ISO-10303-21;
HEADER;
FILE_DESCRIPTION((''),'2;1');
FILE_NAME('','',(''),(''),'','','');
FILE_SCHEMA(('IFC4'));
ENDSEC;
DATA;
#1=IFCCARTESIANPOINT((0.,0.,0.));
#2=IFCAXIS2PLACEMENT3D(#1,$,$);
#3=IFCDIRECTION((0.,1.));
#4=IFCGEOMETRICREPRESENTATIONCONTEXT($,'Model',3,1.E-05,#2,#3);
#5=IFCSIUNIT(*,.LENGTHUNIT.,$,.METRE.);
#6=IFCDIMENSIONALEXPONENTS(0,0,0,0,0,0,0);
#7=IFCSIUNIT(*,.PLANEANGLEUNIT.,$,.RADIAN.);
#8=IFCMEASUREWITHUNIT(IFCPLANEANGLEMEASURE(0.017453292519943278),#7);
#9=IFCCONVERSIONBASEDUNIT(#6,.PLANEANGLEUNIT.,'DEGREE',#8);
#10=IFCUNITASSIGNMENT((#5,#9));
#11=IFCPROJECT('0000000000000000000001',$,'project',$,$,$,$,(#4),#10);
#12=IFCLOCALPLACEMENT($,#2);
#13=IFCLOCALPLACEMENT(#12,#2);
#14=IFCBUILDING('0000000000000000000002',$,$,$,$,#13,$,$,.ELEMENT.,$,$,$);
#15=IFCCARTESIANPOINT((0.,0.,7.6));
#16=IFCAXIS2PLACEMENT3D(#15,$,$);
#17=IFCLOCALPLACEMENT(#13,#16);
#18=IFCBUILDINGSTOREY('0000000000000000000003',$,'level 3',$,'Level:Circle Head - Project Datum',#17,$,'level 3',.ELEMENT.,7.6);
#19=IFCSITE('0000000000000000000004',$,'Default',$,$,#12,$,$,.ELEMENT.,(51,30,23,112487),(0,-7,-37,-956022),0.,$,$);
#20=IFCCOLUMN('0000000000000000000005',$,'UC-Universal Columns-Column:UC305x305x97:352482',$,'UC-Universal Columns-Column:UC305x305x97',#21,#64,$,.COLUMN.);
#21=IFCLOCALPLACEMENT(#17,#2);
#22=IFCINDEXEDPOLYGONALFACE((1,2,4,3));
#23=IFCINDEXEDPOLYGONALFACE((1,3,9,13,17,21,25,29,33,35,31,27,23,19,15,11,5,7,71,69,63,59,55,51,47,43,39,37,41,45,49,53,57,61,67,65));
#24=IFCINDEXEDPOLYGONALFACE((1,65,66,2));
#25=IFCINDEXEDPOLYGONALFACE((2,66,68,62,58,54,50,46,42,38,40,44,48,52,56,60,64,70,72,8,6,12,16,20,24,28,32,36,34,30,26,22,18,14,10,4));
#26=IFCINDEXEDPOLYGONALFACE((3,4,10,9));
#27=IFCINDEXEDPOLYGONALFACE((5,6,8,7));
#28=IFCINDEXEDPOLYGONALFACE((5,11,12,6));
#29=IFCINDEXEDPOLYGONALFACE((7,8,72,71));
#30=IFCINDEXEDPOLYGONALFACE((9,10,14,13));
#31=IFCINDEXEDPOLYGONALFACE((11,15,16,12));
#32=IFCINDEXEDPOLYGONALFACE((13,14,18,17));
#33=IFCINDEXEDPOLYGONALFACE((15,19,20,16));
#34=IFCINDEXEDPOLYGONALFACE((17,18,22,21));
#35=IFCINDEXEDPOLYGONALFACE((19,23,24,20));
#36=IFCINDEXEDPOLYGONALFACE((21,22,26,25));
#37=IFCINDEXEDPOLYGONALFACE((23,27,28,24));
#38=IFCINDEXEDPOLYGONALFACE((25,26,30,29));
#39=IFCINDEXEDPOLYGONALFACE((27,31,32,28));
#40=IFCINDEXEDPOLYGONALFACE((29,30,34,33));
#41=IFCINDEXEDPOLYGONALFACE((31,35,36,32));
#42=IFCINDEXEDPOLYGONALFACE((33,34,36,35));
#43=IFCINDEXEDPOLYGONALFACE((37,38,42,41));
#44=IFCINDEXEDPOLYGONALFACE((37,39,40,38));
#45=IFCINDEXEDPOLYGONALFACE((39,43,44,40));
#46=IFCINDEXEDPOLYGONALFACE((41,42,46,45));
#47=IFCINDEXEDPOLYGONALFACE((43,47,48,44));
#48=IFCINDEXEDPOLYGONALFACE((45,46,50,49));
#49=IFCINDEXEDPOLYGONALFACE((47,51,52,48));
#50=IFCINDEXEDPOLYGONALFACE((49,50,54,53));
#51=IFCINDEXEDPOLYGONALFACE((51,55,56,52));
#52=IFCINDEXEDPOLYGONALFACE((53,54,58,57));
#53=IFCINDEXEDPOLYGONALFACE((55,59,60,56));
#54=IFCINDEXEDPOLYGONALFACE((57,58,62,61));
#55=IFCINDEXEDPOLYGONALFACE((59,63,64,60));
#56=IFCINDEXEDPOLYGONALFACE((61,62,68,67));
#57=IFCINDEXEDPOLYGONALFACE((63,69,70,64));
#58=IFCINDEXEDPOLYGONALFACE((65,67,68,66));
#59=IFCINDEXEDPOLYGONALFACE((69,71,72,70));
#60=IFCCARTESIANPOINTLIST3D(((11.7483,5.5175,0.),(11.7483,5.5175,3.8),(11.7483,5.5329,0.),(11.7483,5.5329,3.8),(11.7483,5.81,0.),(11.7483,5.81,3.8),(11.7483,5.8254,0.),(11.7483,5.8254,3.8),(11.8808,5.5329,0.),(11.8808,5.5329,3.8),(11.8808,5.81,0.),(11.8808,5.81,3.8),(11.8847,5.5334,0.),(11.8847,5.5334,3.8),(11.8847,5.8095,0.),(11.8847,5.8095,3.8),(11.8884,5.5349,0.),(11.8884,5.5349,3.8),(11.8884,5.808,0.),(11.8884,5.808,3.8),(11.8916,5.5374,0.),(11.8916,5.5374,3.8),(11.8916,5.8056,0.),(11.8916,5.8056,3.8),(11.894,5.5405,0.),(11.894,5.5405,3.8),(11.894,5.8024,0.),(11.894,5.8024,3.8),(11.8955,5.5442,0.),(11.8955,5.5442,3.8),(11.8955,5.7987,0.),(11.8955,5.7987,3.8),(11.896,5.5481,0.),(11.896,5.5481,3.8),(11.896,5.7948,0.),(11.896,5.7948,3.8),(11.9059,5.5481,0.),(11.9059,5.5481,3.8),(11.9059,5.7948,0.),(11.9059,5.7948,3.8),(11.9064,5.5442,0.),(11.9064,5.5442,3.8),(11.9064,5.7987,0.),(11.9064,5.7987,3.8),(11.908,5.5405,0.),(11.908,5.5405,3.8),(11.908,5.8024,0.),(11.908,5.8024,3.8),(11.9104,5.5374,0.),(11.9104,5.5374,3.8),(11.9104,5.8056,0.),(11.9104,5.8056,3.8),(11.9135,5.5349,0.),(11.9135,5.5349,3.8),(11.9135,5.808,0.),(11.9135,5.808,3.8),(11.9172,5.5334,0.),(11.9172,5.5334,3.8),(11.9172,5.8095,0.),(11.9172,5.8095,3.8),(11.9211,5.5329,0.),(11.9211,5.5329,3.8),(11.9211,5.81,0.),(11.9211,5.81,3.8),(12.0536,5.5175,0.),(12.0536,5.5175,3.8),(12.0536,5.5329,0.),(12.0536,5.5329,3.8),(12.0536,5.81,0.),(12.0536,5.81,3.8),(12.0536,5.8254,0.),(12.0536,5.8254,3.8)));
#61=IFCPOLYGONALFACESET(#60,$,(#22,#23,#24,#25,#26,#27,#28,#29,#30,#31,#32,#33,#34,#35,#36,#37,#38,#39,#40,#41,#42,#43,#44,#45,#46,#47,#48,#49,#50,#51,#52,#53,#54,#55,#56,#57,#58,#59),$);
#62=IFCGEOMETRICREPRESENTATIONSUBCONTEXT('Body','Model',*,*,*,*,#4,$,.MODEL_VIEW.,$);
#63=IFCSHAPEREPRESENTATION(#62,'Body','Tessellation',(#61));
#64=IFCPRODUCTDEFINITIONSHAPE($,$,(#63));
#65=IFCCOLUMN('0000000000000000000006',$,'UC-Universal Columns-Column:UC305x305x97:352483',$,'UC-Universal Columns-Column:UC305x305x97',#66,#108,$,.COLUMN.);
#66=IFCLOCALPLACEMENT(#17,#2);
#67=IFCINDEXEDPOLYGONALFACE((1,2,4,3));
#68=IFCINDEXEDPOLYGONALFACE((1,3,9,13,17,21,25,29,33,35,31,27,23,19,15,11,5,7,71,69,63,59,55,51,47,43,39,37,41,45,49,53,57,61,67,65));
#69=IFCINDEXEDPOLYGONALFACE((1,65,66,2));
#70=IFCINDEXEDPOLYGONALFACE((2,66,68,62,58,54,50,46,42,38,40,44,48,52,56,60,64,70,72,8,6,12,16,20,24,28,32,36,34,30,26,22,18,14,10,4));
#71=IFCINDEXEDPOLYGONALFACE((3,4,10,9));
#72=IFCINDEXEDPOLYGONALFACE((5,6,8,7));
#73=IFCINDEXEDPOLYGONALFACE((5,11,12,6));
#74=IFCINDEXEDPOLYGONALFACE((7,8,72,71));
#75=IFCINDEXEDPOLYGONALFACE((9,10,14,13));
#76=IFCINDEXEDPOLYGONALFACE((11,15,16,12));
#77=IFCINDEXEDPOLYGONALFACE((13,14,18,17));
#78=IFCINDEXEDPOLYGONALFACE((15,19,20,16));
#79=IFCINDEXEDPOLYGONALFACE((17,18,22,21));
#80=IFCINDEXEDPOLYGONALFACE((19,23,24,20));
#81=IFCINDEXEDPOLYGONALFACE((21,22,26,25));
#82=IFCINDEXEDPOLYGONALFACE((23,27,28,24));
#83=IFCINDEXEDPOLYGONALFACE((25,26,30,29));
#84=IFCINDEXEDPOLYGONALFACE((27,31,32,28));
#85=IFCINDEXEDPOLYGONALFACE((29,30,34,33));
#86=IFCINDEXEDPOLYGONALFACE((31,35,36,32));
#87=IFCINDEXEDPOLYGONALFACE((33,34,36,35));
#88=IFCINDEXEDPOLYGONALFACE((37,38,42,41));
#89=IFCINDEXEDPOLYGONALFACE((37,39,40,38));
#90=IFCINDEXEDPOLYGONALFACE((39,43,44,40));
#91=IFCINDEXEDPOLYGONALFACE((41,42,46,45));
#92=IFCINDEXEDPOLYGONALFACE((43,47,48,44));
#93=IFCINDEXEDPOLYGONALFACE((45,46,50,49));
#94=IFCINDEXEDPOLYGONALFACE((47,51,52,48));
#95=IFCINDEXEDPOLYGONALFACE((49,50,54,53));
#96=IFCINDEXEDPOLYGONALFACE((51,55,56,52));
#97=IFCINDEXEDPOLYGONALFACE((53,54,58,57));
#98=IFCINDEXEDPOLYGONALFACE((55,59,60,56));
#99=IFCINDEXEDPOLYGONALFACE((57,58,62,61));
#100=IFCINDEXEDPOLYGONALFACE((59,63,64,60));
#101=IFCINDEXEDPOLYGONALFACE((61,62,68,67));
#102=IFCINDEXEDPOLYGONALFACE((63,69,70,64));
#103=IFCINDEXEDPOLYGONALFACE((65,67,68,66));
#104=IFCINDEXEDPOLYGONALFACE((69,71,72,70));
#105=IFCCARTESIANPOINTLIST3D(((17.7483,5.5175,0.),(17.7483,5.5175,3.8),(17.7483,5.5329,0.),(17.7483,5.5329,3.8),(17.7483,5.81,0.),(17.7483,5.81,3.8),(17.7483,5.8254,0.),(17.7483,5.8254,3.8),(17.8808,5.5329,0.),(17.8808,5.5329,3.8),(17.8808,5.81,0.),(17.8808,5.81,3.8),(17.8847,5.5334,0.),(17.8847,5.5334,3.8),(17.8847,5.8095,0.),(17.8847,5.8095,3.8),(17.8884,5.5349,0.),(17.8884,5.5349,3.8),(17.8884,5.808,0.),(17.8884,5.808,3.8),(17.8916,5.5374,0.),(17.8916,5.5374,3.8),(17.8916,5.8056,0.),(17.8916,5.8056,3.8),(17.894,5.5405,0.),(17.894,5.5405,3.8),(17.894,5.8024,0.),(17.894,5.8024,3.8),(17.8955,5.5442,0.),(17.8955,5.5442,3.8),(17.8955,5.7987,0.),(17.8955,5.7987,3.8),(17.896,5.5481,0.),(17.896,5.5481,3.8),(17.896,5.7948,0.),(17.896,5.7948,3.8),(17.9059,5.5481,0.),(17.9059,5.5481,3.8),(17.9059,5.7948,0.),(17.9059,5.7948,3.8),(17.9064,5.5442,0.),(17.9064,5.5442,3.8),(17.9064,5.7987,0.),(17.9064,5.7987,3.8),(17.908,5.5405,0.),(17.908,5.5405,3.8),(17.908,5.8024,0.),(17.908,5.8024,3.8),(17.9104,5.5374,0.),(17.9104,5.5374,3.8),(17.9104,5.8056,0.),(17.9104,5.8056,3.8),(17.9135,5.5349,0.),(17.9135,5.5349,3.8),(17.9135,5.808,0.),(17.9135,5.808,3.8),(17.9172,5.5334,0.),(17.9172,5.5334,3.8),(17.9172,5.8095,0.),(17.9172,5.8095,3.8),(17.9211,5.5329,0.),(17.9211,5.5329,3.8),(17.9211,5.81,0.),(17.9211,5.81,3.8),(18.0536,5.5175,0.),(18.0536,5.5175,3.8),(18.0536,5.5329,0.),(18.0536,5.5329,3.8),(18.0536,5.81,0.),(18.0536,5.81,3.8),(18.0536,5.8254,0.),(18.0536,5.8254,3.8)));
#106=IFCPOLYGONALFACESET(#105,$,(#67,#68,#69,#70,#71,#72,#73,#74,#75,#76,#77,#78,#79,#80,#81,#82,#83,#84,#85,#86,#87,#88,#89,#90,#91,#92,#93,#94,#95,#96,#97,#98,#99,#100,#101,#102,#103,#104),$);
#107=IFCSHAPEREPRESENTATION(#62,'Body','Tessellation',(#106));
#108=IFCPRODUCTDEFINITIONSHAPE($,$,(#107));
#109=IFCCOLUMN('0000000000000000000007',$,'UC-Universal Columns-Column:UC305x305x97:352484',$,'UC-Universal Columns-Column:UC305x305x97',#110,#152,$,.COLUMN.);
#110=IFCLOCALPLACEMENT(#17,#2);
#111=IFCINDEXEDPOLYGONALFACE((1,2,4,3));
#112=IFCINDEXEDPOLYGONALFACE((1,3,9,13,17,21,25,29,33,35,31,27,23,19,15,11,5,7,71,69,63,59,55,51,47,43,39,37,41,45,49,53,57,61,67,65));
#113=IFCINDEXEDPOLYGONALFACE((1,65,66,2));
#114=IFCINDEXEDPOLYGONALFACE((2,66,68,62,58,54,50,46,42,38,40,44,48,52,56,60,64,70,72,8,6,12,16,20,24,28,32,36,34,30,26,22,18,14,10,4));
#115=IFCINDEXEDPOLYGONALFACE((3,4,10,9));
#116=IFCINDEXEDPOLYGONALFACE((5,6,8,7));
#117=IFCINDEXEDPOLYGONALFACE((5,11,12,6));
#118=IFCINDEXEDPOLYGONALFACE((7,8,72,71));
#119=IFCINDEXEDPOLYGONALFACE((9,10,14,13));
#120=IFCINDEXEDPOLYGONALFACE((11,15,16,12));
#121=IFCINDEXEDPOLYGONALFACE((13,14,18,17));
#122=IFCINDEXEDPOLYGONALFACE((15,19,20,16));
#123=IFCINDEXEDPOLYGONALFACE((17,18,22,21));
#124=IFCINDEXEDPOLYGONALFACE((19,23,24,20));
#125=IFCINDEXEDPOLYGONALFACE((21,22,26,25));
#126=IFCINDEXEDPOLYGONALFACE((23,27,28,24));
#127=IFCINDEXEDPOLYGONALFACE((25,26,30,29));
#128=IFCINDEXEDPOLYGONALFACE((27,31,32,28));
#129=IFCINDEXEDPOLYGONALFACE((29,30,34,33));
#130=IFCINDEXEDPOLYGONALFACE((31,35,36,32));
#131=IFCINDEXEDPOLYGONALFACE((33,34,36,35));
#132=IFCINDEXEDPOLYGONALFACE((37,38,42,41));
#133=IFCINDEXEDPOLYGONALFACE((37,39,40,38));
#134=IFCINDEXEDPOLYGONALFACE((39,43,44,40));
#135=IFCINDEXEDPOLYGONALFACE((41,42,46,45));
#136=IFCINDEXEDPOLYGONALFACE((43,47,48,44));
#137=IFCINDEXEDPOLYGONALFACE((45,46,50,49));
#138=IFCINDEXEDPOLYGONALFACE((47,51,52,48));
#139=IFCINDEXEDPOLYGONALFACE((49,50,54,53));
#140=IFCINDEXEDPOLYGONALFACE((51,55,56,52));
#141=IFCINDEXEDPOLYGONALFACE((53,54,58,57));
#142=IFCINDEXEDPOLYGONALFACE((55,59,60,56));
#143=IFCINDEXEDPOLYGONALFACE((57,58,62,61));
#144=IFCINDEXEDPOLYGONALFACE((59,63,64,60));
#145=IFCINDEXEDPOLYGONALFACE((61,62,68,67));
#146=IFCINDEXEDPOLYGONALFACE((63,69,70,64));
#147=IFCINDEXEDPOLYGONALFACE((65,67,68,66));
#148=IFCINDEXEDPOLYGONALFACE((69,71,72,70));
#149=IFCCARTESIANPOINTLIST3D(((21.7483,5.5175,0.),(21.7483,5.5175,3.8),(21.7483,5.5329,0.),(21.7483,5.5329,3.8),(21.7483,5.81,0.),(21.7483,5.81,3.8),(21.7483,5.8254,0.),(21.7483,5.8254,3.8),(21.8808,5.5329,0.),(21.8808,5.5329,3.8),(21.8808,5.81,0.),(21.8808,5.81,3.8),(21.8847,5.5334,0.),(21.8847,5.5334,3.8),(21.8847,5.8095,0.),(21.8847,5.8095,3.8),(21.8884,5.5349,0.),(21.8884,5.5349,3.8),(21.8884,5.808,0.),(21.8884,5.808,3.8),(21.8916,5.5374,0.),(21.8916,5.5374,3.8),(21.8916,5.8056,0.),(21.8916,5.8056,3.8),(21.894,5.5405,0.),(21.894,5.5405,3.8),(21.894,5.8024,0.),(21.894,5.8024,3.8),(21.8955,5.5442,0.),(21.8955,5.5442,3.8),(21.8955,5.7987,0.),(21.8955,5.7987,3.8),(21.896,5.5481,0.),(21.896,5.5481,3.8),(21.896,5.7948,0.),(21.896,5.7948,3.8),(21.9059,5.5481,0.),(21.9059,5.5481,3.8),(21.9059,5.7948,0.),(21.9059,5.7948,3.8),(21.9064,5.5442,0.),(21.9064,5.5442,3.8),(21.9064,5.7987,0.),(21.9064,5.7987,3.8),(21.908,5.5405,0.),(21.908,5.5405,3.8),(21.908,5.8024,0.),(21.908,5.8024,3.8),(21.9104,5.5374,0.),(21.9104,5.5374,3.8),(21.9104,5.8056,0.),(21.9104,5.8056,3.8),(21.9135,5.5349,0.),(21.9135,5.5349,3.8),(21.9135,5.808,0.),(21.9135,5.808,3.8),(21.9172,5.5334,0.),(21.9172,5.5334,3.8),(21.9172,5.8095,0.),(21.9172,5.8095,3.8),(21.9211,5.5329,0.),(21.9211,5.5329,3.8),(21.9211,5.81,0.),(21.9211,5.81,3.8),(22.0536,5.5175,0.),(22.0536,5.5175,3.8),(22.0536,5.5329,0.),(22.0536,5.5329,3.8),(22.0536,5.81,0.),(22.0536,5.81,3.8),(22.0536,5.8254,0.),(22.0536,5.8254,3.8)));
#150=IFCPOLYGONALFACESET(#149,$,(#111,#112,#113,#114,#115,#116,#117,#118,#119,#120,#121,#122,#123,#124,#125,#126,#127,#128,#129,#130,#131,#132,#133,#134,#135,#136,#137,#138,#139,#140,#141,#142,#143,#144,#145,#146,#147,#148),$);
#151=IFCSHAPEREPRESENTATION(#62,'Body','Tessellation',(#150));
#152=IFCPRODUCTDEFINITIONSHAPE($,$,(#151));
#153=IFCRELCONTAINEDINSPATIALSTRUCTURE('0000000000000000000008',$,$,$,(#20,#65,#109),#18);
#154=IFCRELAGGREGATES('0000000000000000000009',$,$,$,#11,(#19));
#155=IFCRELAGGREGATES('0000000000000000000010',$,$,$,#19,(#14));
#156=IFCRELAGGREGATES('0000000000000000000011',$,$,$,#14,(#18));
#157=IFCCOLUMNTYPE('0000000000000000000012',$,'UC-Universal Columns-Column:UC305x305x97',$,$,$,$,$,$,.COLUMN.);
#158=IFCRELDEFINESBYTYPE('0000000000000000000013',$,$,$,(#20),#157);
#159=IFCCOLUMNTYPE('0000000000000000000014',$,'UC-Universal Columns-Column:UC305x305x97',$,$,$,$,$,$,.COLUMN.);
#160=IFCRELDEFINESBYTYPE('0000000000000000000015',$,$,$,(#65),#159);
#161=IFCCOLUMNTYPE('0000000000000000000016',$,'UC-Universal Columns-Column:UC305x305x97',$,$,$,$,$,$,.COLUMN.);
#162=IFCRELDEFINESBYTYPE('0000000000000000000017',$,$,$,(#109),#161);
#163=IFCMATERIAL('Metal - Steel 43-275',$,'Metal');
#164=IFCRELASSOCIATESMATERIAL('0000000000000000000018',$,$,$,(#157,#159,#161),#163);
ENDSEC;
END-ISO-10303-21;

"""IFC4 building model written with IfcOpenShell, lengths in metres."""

from ifc_helpers import new_model, entity, si_unit, converted_unit, direction, frame, frame_2d, origin, place, context, subcontext, project, spatial, i_section, extrude, source, transform, mapped, material, material_profile, profile_set, type_object, type_shapes, element, save


model = new_model("IFC4")

# Units and contexts
model_context = context("Model", 3, precision=1e-05, world=origin(), true_north=direction((0.0, 1.0)))
body_context = subcontext(model_context, "Body", "Model", "MODEL_VIEW")
ifc_project = project(units=[si_unit("LENGTHUNIT", "METRE"), converted_unit("PLANEANGLEUNIT", "DEGREE", entity("IfcPlaneAngleMeasure", 0.017453292519943278), si_unit("PLANEANGLEUNIT", "RADIAN"), dimensions=[0, 0, 0, 0, 0, 0, 0])], contexts=[model_context])

# Site, building, storey
site_placement = place(None, origin())
site = spatial("IfcSite", under=ifc_project, at=site_placement, Name="Default", CompositionType="ELEMENT", RefLatitude=(51, 30, 23, 112487), RefLongitude=(0, -7, -37, -956022), RefElevation=0.0)
building_placement = place(site_placement, origin())
building = spatial("IfcBuilding", under=site, at=building_placement, CompositionType="ELEMENT")
storey_placement = place(building_placement, frame((0.0, 0.0, 7.6)))
storey = spatial("IfcBuildingStorey", under=building, at=storey_placement, Name="level 3", ObjectType="Level:Circle Head - Project Datum", LongName="level 3", CompositionType="ELEMENT", Elevation=7.6)

# Columns
ifc_material_1 = material(Name="Metal - Steel 43-275", Category="Metal")
ifc_material_profile_1 = material_profile(ifc_material_1, i_section(OverallWidth=0.3053, OverallDepth=0.3079, WebThickness=0.0099, FlangeThickness=0.0154, FilletRadius=0.0152, at=frame_2d((0.0, 0.0), x_axis=(1.0, 0.0))), Name="UC305x305x97")
ifc_profile_set_1 = profile_set([ifc_material_profile_1], Name="UC305x305x97")
column_type_1 = type_object("IfcColumnType", Name="UC-Universal Columns-Column:UC305x305x97", PredefinedType="COLUMN", material=ifc_profile_set_1)
shared_shape_1 = source(origin(), body_context, "Body", "SweptSolid", [
    extrude(i_section(OverallWidth=0.3053, OverallDepth=0.3079, WebThickness=0.0099, FlangeThickness=0.0154, FilletRadius=0.0152, at=frame_2d((0.0, 0.0), x_axis=(1.0, 0.0))), frame((11.901, 5.6715, 7.6), z_axis=(0.0, 0.0, 1.0), x_axis=(-1.0, 0.0, 0.0)), (0.0, 0.0, 1.0), 3.8),
])
type_shapes(column_type_1, [shared_shape_1])
column_1_placement = place(storey_placement, frame((0.0, 0.0, -7.6)))
element("IfcColumn", 1, at=column_1_placement, inside=storey, type_object=column_type_1, Name="UC-Universal Columns-Column:UC305x305x97:352482", ObjectType="UC-Universal Columns-Column:UC305x305x97", PredefinedType="COLUMN", context=body_context, shape_type="MappedRepresentation", body=[
    mapped(shared_shape_1, transform((0.0, 0.0, 0.0), scale=1.0)),
])
column_type_2 = type_object("IfcColumnType", Name="UC-Universal Columns-Column:UC305x305x97", PredefinedType="COLUMN", material=ifc_profile_set_1)
shared_shape_2 = source(origin(), body_context, "Body", "SweptSolid", [
    extrude(i_section(OverallWidth=0.3053, OverallDepth=0.3079, WebThickness=0.0099, FlangeThickness=0.0154, FilletRadius=0.0152, at=frame_2d((0.0, 0.0), x_axis=(1.0, 0.0))), frame((17.901, 5.6715, 7.6), z_axis=(0.0, 0.0, 1.0), x_axis=(-1.0, 0.0, 0.0)), (0.0, 0.0, 1.0), 3.8),
])
type_shapes(column_type_2, [shared_shape_2])
column_2_placement = place(storey_placement, frame((0.0, 0.0, -7.6)))
element("IfcColumn", 2, at=column_2_placement, inside=storey, type_object=column_type_2, Name="UC-Universal Columns-Column:UC305x305x97:352483", ObjectType="UC-Universal Columns-Column:UC305x305x97", PredefinedType="COLUMN", context=body_context, shape_type="MappedRepresentation", body=[
    mapped(shared_shape_2, transform((0.0, 0.0, 0.0), scale=1.0)),
])
column_type_3 = type_object("IfcColumnType", Name="UC-Universal Columns-Column:UC305x305x97", PredefinedType="COLUMN", material=ifc_profile_set_1)
shared_shape_3 = source(origin(), body_context, "Body", "SweptSolid", [
    extrude(i_section(OverallWidth=0.3053, OverallDepth=0.3079, WebThickness=0.0099, FlangeThickness=0.0154, FilletRadius=0.0152, at=frame_2d((0.0, 0.0), x_axis=(1.0, 0.0))), frame((21.901, 5.6715, 7.6), z_axis=(0.0, 0.0, 1.0), x_axis=(-1.0, 0.0, 0.0)), (0.0, 0.0, 1.0), 3.8),
])
type_shapes(column_type_3, [shared_shape_3])
column_3_placement = place(storey_placement, frame((0.0, 0.0, -7.6)))
element("IfcColumn", 3, at=column_3_placement, inside=storey, type_object=column_type_3, Name="UC-Universal Columns-Column:UC305x305x97:352484", ObjectType="UC-Universal Columns-Column:UC305x305x97", PredefinedType="COLUMN", context=body_context, shape_type="MappedRepresentation", body=[
    mapped(shared_shape_3, transform((0.0, 0.0, 0.0), scale=1.0)),
])

save(model, "model.ifc")
